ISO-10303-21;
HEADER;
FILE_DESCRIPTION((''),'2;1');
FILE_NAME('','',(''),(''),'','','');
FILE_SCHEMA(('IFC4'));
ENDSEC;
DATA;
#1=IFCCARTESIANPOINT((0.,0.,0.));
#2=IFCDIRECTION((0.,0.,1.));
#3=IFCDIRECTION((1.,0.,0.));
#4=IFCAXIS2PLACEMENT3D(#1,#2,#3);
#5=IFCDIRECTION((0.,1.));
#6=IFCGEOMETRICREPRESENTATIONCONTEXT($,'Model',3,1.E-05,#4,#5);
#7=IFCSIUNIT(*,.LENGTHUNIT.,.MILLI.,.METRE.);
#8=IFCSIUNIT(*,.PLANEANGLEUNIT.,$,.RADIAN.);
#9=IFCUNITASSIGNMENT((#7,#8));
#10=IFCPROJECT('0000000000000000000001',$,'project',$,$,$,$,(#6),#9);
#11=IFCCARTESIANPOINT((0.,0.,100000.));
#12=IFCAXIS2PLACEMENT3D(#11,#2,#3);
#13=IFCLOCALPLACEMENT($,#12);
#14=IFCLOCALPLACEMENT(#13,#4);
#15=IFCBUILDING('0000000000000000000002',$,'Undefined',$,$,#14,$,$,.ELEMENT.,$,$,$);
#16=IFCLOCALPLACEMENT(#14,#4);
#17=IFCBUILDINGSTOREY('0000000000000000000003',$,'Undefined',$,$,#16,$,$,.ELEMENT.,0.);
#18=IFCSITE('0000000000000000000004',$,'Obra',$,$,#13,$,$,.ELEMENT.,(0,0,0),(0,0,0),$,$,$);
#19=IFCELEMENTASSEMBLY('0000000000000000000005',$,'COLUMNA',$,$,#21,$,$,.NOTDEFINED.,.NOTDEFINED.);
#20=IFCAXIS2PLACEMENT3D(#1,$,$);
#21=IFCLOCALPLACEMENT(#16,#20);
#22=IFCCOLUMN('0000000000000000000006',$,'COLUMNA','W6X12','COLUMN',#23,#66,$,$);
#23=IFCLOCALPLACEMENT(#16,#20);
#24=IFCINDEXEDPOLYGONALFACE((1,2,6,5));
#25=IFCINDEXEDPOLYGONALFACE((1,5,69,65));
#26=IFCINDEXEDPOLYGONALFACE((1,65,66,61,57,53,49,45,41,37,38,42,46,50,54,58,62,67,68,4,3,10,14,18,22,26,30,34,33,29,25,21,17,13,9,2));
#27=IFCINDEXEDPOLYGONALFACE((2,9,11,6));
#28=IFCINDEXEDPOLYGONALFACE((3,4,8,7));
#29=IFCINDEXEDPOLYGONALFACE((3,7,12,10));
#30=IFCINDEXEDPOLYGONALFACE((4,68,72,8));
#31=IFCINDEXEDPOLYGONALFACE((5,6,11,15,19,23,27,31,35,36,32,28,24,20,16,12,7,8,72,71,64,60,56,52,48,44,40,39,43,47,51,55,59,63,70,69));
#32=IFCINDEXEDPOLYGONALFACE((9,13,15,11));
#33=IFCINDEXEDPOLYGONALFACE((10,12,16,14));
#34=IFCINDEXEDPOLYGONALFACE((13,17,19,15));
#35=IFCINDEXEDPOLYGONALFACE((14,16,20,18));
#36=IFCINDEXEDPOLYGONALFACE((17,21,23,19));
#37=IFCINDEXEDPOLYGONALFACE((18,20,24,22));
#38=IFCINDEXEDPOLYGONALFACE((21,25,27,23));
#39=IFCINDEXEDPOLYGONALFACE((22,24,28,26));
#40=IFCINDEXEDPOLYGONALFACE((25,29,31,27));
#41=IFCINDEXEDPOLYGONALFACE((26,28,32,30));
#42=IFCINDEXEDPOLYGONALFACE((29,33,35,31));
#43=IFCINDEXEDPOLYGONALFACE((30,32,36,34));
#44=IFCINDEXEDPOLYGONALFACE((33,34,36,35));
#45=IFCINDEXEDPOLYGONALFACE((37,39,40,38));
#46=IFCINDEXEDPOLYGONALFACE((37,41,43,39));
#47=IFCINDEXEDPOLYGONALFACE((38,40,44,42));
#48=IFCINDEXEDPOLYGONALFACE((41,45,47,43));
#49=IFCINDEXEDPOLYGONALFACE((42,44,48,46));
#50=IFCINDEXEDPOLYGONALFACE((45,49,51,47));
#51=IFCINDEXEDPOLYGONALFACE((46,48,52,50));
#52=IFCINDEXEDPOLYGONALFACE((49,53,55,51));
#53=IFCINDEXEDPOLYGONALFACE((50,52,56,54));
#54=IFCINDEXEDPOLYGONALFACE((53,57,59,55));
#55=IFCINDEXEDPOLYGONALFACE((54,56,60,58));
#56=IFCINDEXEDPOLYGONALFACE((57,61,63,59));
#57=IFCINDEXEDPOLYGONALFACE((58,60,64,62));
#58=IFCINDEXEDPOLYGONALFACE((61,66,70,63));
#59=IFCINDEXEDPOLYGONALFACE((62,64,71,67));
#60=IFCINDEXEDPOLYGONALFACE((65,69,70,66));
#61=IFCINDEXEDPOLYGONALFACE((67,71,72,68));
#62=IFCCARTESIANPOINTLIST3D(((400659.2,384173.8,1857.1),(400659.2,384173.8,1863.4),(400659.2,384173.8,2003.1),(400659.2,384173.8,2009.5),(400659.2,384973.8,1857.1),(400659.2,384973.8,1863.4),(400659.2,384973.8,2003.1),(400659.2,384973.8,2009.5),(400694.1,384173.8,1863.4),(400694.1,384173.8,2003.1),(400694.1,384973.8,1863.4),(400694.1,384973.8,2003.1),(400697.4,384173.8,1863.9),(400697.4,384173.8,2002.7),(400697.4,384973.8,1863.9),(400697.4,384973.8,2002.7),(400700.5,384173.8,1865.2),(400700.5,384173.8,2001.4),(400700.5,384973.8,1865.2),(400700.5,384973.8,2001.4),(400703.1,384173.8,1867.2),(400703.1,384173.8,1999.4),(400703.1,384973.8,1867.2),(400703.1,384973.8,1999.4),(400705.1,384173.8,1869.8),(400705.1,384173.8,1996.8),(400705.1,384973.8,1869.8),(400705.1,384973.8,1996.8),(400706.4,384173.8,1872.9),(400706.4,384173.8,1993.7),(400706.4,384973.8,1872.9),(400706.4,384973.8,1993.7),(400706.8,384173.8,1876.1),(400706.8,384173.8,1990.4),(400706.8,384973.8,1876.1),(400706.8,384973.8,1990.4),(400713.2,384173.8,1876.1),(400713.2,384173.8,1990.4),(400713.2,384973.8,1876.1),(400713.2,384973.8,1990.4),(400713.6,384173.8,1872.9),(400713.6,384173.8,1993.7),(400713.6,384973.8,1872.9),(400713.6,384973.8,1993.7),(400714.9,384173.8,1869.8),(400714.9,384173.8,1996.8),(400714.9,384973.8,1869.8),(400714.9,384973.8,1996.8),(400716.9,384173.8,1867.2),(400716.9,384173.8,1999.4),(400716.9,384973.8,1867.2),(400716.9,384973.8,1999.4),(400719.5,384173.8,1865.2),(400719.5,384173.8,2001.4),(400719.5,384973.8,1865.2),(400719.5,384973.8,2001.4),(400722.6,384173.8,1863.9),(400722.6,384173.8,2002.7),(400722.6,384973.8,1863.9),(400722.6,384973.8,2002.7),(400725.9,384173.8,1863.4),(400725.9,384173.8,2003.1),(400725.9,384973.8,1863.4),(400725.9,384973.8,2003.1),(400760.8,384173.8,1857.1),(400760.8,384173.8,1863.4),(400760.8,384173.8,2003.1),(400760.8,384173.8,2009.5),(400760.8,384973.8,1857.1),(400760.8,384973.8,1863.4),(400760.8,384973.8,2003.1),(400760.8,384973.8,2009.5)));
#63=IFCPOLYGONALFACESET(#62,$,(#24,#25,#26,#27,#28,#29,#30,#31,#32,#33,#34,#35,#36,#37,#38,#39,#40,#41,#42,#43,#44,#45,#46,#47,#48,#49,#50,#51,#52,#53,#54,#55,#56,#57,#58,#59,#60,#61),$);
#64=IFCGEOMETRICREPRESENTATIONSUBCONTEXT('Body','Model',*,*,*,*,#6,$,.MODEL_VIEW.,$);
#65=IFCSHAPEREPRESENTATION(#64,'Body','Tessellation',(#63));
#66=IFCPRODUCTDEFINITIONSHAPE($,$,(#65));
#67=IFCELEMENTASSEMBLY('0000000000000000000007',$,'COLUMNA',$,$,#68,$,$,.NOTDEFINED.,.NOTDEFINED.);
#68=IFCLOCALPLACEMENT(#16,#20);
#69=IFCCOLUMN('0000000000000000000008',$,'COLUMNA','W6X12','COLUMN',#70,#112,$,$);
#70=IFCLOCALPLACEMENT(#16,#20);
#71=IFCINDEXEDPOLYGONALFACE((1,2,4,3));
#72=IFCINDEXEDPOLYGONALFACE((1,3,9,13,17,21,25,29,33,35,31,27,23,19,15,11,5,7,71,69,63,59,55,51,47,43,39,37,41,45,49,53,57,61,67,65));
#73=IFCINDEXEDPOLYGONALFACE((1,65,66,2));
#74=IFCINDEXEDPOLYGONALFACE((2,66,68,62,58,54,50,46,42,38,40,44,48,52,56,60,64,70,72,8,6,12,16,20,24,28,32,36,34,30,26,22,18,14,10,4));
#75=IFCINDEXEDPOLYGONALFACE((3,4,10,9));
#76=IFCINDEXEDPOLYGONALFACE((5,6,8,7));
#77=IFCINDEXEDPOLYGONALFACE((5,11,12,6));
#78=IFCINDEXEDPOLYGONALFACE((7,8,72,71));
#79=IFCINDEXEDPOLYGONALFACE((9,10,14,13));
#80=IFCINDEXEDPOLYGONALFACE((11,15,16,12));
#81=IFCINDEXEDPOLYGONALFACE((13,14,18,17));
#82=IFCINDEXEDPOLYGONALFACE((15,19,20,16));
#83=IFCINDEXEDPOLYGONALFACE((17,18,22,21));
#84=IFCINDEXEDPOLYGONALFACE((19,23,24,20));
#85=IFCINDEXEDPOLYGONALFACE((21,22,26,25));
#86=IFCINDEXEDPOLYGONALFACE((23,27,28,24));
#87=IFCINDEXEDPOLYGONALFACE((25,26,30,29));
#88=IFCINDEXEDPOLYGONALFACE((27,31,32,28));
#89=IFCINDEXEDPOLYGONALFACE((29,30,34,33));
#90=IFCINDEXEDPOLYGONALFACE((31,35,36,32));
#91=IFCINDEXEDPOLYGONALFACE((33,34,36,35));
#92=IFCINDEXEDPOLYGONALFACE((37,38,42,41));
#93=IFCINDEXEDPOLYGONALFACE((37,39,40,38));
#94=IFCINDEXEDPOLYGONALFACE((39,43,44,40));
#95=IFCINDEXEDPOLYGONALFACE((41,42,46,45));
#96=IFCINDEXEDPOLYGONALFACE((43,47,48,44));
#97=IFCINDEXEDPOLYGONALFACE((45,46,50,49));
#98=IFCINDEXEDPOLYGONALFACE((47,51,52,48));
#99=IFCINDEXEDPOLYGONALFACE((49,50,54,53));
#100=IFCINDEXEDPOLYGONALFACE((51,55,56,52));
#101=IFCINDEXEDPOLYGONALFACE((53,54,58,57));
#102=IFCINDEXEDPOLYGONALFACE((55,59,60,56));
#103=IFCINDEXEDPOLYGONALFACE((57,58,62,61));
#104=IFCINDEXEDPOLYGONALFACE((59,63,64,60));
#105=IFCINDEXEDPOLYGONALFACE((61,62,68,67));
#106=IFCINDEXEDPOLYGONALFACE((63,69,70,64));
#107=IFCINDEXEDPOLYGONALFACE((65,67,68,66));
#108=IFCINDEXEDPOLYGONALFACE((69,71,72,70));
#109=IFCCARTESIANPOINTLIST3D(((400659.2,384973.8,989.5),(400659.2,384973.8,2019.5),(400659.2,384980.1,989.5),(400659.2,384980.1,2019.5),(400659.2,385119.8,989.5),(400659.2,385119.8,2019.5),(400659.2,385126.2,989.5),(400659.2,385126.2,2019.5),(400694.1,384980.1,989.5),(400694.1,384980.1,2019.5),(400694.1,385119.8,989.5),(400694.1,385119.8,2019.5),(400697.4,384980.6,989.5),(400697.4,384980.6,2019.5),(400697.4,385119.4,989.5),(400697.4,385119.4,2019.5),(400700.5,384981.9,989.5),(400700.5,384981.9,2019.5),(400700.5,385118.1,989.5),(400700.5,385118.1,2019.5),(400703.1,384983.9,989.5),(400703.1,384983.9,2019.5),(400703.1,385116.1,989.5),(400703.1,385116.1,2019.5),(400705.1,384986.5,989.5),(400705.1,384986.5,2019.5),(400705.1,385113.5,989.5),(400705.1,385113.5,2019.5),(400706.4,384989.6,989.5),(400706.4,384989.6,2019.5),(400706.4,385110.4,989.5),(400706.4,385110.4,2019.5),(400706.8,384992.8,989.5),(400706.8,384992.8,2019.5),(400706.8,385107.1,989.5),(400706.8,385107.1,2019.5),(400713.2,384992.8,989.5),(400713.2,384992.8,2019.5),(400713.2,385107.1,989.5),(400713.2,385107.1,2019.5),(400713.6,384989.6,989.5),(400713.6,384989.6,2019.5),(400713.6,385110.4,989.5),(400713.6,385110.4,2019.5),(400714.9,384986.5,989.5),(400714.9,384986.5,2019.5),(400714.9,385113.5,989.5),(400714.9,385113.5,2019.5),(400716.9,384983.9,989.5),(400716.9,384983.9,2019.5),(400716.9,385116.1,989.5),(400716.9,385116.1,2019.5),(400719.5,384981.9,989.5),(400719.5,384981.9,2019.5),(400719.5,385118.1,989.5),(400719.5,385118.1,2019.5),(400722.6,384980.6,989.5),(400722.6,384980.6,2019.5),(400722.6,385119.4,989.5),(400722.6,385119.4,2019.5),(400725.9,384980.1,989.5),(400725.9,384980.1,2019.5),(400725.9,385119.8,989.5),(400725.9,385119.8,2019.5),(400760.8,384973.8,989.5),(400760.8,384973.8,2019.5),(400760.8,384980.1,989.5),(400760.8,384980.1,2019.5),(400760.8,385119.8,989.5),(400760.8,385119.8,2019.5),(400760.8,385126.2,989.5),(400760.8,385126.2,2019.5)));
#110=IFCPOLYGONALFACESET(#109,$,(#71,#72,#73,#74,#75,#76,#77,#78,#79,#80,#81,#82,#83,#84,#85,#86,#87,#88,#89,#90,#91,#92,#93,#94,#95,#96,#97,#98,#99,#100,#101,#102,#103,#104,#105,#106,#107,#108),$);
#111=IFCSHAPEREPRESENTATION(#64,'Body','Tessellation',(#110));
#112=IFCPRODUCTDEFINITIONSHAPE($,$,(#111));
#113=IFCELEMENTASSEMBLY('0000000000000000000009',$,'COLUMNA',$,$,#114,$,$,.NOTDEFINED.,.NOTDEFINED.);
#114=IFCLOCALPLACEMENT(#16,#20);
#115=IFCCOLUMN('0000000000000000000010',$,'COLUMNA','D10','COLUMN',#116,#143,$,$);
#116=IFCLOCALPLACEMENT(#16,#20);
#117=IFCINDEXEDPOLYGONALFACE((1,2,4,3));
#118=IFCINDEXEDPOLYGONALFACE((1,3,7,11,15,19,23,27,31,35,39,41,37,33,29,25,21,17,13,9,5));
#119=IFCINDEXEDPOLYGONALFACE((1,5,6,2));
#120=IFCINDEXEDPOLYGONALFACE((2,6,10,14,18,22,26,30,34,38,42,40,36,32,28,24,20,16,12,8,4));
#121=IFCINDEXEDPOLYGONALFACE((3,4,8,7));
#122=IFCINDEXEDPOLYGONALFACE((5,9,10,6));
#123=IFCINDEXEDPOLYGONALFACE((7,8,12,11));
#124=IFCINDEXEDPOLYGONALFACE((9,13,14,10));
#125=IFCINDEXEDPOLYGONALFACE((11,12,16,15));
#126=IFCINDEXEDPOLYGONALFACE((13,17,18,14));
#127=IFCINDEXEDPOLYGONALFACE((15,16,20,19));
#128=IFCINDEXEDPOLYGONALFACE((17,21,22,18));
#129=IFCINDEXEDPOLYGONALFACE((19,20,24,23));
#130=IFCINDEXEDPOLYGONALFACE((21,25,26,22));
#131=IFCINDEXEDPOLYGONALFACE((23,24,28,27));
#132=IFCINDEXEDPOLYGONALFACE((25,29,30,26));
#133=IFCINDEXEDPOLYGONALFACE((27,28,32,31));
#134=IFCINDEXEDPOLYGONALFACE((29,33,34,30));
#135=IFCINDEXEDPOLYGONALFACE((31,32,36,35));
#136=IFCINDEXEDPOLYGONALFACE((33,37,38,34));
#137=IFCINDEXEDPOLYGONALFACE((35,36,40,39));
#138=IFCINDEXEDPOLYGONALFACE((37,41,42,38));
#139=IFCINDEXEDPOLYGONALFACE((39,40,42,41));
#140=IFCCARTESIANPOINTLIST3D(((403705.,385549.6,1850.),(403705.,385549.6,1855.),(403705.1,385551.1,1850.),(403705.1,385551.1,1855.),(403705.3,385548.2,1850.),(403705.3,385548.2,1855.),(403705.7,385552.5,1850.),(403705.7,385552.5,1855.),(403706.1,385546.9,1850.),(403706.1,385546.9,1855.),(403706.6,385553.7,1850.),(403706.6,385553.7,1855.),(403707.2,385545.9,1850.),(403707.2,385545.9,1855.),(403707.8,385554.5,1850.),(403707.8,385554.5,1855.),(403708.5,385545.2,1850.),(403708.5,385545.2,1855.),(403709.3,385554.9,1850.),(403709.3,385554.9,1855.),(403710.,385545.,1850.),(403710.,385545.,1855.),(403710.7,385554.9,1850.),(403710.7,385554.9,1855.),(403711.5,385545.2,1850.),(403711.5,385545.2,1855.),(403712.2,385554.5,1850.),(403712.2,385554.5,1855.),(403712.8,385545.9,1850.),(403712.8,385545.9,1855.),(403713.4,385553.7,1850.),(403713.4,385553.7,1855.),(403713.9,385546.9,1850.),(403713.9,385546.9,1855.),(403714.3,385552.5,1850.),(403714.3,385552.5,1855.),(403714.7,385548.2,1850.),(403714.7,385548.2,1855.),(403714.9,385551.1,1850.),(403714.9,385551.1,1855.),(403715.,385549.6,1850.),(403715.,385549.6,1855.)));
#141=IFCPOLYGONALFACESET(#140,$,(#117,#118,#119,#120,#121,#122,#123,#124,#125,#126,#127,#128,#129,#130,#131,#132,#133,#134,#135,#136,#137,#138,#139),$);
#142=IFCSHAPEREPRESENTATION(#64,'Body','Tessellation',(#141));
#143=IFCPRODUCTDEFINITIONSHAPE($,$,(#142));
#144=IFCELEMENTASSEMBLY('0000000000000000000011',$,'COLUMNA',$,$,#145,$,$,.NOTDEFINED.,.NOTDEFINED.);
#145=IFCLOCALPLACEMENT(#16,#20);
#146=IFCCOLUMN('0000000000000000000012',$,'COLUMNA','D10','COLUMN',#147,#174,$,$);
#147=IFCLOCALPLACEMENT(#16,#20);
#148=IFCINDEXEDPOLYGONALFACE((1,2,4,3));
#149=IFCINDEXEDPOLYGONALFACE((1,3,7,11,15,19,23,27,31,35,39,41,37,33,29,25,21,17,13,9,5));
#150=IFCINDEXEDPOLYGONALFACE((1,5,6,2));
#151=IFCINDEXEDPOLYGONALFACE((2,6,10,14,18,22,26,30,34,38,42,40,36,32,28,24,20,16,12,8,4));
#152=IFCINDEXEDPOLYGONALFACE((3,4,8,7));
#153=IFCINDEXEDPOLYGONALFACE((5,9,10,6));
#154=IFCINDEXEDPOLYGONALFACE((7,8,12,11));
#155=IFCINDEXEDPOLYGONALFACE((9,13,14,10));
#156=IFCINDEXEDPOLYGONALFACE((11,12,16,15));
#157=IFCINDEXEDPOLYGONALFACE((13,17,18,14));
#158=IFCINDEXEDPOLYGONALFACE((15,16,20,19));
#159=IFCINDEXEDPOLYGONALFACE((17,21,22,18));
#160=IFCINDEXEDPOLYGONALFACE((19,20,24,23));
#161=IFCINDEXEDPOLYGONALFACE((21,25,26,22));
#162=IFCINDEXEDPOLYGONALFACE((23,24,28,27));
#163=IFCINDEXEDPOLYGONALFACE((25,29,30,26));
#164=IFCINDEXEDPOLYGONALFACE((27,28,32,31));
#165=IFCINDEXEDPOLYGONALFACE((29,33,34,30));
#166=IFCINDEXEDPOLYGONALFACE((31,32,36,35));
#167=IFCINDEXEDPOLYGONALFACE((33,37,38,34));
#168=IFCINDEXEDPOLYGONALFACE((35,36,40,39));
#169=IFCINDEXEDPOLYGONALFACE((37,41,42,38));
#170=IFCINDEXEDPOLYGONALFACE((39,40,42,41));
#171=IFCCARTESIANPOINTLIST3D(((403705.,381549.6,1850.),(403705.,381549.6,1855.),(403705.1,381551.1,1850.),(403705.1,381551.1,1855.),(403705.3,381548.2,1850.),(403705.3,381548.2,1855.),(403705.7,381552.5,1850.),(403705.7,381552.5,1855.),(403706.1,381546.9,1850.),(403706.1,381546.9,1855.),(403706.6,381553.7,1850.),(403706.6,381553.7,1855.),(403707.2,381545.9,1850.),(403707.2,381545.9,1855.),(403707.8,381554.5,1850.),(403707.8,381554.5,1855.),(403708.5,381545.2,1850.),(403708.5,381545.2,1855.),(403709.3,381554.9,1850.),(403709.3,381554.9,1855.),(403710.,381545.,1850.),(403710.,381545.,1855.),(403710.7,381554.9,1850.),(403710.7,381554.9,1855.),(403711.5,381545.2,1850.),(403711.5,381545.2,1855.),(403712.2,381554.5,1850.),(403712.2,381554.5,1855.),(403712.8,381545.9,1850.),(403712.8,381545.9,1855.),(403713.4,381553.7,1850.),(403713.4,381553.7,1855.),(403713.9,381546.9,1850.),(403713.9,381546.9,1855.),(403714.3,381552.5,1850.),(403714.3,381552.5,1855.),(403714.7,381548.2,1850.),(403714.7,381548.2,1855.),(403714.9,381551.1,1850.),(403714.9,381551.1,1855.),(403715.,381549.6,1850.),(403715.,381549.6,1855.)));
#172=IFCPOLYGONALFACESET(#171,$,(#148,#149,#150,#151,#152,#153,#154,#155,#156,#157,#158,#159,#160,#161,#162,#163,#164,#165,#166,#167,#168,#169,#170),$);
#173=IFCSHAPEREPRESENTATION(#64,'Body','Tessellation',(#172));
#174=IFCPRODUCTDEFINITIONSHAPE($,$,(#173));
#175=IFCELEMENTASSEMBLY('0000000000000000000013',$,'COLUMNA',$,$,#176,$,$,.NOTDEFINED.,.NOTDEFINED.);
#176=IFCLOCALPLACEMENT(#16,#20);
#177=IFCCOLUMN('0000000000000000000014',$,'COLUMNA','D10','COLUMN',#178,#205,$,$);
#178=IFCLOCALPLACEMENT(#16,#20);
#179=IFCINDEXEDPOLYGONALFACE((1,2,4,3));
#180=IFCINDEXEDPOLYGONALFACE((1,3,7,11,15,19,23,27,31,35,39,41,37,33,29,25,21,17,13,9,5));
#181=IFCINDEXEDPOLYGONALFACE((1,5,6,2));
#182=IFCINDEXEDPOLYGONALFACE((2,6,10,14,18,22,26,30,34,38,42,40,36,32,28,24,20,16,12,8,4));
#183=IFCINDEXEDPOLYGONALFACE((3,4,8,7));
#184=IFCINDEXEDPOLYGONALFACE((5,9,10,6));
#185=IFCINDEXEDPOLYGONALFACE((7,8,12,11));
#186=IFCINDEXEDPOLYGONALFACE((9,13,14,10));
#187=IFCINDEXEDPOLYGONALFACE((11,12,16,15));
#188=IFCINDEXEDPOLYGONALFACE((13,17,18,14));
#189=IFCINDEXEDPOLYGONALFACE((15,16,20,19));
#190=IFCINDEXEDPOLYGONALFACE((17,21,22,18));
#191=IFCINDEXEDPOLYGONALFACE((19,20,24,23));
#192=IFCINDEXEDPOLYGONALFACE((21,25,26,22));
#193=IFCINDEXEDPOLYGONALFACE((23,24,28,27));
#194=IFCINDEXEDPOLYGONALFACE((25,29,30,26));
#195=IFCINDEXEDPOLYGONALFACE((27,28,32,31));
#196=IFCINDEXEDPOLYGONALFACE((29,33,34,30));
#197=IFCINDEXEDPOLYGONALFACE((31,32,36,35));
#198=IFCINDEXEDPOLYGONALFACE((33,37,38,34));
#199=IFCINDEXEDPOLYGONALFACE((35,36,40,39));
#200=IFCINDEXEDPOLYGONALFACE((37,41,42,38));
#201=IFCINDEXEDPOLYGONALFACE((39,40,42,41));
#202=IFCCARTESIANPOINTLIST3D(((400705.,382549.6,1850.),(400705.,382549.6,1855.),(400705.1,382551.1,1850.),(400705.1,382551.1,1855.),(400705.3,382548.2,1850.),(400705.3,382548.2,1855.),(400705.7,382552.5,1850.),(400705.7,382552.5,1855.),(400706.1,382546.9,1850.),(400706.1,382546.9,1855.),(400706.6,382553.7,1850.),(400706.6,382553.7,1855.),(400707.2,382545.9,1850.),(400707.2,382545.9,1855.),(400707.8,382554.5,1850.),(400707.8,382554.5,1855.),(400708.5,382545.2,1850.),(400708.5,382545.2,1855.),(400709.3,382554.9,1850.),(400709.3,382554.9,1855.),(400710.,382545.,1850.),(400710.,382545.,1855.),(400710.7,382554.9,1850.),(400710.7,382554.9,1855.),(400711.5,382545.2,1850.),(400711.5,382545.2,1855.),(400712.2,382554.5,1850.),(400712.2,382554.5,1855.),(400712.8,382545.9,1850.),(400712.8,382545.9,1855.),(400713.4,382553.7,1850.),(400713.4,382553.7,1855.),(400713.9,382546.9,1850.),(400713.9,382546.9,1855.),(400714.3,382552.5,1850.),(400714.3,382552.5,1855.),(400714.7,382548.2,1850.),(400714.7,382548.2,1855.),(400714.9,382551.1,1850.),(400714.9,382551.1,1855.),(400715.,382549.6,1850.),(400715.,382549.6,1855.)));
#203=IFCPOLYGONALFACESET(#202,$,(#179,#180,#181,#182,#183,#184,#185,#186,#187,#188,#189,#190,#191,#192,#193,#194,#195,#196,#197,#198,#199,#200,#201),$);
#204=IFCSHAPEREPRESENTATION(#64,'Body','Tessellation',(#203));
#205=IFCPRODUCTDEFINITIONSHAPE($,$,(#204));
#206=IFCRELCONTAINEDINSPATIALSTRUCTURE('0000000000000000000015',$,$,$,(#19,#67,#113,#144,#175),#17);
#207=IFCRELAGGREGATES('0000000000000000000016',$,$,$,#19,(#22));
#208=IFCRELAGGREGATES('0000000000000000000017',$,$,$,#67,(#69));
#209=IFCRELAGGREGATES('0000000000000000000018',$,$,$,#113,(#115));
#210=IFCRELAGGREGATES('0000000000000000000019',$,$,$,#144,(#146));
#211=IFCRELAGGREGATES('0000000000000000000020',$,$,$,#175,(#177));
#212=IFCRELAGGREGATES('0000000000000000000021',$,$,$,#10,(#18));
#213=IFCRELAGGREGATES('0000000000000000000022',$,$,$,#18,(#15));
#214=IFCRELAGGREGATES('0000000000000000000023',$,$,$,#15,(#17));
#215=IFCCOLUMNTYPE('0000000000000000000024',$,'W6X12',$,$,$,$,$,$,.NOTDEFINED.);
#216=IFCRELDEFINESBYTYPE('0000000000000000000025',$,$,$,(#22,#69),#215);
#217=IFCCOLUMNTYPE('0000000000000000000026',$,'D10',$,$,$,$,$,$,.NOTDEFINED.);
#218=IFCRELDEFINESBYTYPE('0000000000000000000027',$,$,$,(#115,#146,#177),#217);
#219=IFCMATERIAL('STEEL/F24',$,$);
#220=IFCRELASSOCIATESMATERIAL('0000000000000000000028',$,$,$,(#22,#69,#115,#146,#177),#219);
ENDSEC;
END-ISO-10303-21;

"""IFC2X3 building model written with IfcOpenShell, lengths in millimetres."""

from ifc_helpers import new_model, si_unit, direction, frame, origin_with_axes, origin_2d_with_axis, place, context, subcontext, project, spatial, circle, i_section, extrude, material, type_object, element, aggregate, save


model = new_model("IFC2X3")

# Units and contexts
model_context = context("Model", 3, precision=1e-05, world=origin_with_axes(), true_north=direction((0.0, 1.0)))
body_context = subcontext(model_context, "Body", "Model", "MODEL_VIEW")
ifc_project = project(units=[si_unit("LENGTHUNIT", "METRE", prefix="MILLI"), si_unit("PLANEANGLEUNIT", "RADIAN")], contexts=[model_context])

# Site, building, storey
site_placement = place(None, frame((0.0, 0.0, 100000.0), z_axis=(0.0, 0.0, 1.0), x_axis=(1.0, 0.0, 0.0)))
site = spatial("IfcSite", under=ifc_project, at=site_placement, Name="Obra", CompositionType="ELEMENT", RefLatitude=(0, 0, 0), RefLongitude=(0, 0, 0))
building_placement = place(site_placement, origin_with_axes())
building = spatial("IfcBuilding", under=site, at=building_placement, Name="Undefined", CompositionType="ELEMENT")
storey_placement = place(building_placement, origin_with_axes())
storey = spatial("IfcBuildingStorey", under=building, at=storey_placement, Name="Undefined", CompositionType="ELEMENT", Elevation=0.0)

# Element assemblies, columns
ifc_material_1 = material(Name="STEEL/F24")
column_type_1 = type_object("IfcColumnType", Name="W6X12", PredefinedType="NOTDEFINED")
assembly_1_placement = place(storey_placement, origin_with_axes())
assembly_1 = element("IfcElementAssembly", 1, at=assembly_1_placement, inside=storey, Name="COLUMNA", AssemblyPlace="NOTDEFINED", PredefinedType="NOTDEFINED")
column_1_placement = place(assembly_1_placement, frame((400710.0, 384973.8, 1933.3), z_axis=(0.0, -1.0, 0.0), x_axis=(0.0, 0.0, -1.0)))
column_1 = element("IfcColumn", 2, at=column_1_placement, type_object=column_type_1, material=ifc_material_1, Name="COLUMNA", Description="W6X12", ObjectType="COLUMN", context=body_context, shape_type="SweptSolid", body=[
    extrude(i_section(OverallWidth=101.6, OverallDepth=152.4, WebThickness=6.3, FlangeThickness=6.3, FilletRadius=12.7, at=origin_2d_with_axis()), frame((0.0, 0.0, 800.0), z_axis=(0.0, 0.0, -1.0), x_axis=(0.0, 1.0, 0.0)), (0.0, 0.0, 1.0), 800.0),
])
aggregate(assembly_1, [column_1])
assembly_2_placement = place(storey_placement, origin_with_axes())
assembly_2 = element("IfcElementAssembly", 3, at=assembly_2_placement, inside=storey, Name="COLUMNA", AssemblyPlace="NOTDEFINED", PredefinedType="NOTDEFINED")
column_2_placement = place(assembly_2_placement, frame((400710.0, 385050.0, 989.5), z_axis=(0.0, 0.0, 1.0), x_axis=(0.0, 1.0, 0.0)))
column_2 = element("IfcColumn", 4, at=column_2_placement, type_object=column_type_1, material=ifc_material_1, Name="COLUMNA", Description="W6X12", ObjectType="COLUMN", context=body_context, shape_type="SweptSolid", body=[
    extrude(i_section(OverallWidth=101.6, OverallDepth=152.4, WebThickness=6.3, FlangeThickness=6.3, FilletRadius=12.7, at=origin_2d_with_axis()), frame((0.0, 0.0, 1030.0), z_axis=(0.0, 0.0, -1.0), x_axis=(0.0, 1.0, 0.0)), (0.0, 0.0, 1.0), 1030.0),
])
aggregate(assembly_2, [column_2])
assembly_3_placement = place(storey_placement, origin_with_axes())
assembly_3 = element("IfcElementAssembly", 5, at=assembly_3_placement, inside=storey, Name="COLUMNA", AssemblyPlace="NOTDEFINED", PredefinedType="NOTDEFINED")
column_type_2 = type_object("IfcColumnType", Name="D10", PredefinedType="NOTDEFINED")
column_3_placement = place(assembly_3_placement, frame((403710.0, 385550.0, 1850.0), z_axis=(0.0, 0.0, 1.0), x_axis=(-1.0, 0.0, 0.0)))
column_3 = element("IfcColumn", 6, at=column_3_placement, type_object=column_type_2, material=ifc_material_1, Name="COLUMNA", Description="D10", ObjectType="COLUMN", context=body_context, shape_type="SweptSolid", body=[
    extrude(circle(Radius=5.0, at=origin_2d_with_axis()), frame((0.0, 0.0, 5.0), z_axis=(0.0, 0.0, -1.0), x_axis=(0.0, 1.0, 0.0)), (0.0, 0.0, 1.0), 5.0),
])
aggregate(assembly_3, [column_3])
assembly_4_placement = place(storey_placement, origin_with_axes())
assembly_4 = element("IfcElementAssembly", 7, at=assembly_4_placement, inside=storey, Name="COLUMNA", AssemblyPlace="NOTDEFINED", PredefinedType="NOTDEFINED")
column_4_placement = place(assembly_4_placement, frame((403710.0, 381550.0, 1850.0), z_axis=(0.0, 0.0, 1.0), x_axis=(-1.0, 0.0, 0.0)))
column_4 = element("IfcColumn", 8, at=column_4_placement, type_object=column_type_2, material=ifc_material_1, Name="COLUMNA", Description="D10", ObjectType="COLUMN", context=body_context, shape_type="SweptSolid", body=[
    extrude(circle(Radius=5.0, at=origin_2d_with_axis()), frame((0.0, 0.0, 5.0), z_axis=(0.0, 0.0, -1.0), x_axis=(0.0, 1.0, 0.0)), (0.0, 0.0, 1.0), 5.0),
])
aggregate(assembly_4, [column_4])
assembly_5_placement = place(storey_placement, origin_with_axes())
assembly_5 = element("IfcElementAssembly", 9, at=assembly_5_placement, inside=storey, Name="COLUMNA", AssemblyPlace="NOTDEFINED", PredefinedType="NOTDEFINED")
column_5_placement = place(assembly_5_placement, frame((400710.0, 382550.0, 1850.0), z_axis=(0.0, 0.0, 1.0), x_axis=(-1.0, 0.0, 0.0)))
column_5 = element("IfcColumn", 10, at=column_5_placement, type_object=column_type_2, material=ifc_material_1, Name="COLUMNA", Description="D10", ObjectType="COLUMN", context=body_context, shape_type="SweptSolid", body=[
    extrude(circle(Radius=5.0, at=origin_2d_with_axis()), frame((0.0, 0.0, 5.0), z_axis=(0.0, 0.0, -1.0), x_axis=(0.0, 1.0, 0.0)), (0.0, 0.0, 1.0), 5.0),
])
aggregate(assembly_5, [column_5])

save(model, "model.ifc")
